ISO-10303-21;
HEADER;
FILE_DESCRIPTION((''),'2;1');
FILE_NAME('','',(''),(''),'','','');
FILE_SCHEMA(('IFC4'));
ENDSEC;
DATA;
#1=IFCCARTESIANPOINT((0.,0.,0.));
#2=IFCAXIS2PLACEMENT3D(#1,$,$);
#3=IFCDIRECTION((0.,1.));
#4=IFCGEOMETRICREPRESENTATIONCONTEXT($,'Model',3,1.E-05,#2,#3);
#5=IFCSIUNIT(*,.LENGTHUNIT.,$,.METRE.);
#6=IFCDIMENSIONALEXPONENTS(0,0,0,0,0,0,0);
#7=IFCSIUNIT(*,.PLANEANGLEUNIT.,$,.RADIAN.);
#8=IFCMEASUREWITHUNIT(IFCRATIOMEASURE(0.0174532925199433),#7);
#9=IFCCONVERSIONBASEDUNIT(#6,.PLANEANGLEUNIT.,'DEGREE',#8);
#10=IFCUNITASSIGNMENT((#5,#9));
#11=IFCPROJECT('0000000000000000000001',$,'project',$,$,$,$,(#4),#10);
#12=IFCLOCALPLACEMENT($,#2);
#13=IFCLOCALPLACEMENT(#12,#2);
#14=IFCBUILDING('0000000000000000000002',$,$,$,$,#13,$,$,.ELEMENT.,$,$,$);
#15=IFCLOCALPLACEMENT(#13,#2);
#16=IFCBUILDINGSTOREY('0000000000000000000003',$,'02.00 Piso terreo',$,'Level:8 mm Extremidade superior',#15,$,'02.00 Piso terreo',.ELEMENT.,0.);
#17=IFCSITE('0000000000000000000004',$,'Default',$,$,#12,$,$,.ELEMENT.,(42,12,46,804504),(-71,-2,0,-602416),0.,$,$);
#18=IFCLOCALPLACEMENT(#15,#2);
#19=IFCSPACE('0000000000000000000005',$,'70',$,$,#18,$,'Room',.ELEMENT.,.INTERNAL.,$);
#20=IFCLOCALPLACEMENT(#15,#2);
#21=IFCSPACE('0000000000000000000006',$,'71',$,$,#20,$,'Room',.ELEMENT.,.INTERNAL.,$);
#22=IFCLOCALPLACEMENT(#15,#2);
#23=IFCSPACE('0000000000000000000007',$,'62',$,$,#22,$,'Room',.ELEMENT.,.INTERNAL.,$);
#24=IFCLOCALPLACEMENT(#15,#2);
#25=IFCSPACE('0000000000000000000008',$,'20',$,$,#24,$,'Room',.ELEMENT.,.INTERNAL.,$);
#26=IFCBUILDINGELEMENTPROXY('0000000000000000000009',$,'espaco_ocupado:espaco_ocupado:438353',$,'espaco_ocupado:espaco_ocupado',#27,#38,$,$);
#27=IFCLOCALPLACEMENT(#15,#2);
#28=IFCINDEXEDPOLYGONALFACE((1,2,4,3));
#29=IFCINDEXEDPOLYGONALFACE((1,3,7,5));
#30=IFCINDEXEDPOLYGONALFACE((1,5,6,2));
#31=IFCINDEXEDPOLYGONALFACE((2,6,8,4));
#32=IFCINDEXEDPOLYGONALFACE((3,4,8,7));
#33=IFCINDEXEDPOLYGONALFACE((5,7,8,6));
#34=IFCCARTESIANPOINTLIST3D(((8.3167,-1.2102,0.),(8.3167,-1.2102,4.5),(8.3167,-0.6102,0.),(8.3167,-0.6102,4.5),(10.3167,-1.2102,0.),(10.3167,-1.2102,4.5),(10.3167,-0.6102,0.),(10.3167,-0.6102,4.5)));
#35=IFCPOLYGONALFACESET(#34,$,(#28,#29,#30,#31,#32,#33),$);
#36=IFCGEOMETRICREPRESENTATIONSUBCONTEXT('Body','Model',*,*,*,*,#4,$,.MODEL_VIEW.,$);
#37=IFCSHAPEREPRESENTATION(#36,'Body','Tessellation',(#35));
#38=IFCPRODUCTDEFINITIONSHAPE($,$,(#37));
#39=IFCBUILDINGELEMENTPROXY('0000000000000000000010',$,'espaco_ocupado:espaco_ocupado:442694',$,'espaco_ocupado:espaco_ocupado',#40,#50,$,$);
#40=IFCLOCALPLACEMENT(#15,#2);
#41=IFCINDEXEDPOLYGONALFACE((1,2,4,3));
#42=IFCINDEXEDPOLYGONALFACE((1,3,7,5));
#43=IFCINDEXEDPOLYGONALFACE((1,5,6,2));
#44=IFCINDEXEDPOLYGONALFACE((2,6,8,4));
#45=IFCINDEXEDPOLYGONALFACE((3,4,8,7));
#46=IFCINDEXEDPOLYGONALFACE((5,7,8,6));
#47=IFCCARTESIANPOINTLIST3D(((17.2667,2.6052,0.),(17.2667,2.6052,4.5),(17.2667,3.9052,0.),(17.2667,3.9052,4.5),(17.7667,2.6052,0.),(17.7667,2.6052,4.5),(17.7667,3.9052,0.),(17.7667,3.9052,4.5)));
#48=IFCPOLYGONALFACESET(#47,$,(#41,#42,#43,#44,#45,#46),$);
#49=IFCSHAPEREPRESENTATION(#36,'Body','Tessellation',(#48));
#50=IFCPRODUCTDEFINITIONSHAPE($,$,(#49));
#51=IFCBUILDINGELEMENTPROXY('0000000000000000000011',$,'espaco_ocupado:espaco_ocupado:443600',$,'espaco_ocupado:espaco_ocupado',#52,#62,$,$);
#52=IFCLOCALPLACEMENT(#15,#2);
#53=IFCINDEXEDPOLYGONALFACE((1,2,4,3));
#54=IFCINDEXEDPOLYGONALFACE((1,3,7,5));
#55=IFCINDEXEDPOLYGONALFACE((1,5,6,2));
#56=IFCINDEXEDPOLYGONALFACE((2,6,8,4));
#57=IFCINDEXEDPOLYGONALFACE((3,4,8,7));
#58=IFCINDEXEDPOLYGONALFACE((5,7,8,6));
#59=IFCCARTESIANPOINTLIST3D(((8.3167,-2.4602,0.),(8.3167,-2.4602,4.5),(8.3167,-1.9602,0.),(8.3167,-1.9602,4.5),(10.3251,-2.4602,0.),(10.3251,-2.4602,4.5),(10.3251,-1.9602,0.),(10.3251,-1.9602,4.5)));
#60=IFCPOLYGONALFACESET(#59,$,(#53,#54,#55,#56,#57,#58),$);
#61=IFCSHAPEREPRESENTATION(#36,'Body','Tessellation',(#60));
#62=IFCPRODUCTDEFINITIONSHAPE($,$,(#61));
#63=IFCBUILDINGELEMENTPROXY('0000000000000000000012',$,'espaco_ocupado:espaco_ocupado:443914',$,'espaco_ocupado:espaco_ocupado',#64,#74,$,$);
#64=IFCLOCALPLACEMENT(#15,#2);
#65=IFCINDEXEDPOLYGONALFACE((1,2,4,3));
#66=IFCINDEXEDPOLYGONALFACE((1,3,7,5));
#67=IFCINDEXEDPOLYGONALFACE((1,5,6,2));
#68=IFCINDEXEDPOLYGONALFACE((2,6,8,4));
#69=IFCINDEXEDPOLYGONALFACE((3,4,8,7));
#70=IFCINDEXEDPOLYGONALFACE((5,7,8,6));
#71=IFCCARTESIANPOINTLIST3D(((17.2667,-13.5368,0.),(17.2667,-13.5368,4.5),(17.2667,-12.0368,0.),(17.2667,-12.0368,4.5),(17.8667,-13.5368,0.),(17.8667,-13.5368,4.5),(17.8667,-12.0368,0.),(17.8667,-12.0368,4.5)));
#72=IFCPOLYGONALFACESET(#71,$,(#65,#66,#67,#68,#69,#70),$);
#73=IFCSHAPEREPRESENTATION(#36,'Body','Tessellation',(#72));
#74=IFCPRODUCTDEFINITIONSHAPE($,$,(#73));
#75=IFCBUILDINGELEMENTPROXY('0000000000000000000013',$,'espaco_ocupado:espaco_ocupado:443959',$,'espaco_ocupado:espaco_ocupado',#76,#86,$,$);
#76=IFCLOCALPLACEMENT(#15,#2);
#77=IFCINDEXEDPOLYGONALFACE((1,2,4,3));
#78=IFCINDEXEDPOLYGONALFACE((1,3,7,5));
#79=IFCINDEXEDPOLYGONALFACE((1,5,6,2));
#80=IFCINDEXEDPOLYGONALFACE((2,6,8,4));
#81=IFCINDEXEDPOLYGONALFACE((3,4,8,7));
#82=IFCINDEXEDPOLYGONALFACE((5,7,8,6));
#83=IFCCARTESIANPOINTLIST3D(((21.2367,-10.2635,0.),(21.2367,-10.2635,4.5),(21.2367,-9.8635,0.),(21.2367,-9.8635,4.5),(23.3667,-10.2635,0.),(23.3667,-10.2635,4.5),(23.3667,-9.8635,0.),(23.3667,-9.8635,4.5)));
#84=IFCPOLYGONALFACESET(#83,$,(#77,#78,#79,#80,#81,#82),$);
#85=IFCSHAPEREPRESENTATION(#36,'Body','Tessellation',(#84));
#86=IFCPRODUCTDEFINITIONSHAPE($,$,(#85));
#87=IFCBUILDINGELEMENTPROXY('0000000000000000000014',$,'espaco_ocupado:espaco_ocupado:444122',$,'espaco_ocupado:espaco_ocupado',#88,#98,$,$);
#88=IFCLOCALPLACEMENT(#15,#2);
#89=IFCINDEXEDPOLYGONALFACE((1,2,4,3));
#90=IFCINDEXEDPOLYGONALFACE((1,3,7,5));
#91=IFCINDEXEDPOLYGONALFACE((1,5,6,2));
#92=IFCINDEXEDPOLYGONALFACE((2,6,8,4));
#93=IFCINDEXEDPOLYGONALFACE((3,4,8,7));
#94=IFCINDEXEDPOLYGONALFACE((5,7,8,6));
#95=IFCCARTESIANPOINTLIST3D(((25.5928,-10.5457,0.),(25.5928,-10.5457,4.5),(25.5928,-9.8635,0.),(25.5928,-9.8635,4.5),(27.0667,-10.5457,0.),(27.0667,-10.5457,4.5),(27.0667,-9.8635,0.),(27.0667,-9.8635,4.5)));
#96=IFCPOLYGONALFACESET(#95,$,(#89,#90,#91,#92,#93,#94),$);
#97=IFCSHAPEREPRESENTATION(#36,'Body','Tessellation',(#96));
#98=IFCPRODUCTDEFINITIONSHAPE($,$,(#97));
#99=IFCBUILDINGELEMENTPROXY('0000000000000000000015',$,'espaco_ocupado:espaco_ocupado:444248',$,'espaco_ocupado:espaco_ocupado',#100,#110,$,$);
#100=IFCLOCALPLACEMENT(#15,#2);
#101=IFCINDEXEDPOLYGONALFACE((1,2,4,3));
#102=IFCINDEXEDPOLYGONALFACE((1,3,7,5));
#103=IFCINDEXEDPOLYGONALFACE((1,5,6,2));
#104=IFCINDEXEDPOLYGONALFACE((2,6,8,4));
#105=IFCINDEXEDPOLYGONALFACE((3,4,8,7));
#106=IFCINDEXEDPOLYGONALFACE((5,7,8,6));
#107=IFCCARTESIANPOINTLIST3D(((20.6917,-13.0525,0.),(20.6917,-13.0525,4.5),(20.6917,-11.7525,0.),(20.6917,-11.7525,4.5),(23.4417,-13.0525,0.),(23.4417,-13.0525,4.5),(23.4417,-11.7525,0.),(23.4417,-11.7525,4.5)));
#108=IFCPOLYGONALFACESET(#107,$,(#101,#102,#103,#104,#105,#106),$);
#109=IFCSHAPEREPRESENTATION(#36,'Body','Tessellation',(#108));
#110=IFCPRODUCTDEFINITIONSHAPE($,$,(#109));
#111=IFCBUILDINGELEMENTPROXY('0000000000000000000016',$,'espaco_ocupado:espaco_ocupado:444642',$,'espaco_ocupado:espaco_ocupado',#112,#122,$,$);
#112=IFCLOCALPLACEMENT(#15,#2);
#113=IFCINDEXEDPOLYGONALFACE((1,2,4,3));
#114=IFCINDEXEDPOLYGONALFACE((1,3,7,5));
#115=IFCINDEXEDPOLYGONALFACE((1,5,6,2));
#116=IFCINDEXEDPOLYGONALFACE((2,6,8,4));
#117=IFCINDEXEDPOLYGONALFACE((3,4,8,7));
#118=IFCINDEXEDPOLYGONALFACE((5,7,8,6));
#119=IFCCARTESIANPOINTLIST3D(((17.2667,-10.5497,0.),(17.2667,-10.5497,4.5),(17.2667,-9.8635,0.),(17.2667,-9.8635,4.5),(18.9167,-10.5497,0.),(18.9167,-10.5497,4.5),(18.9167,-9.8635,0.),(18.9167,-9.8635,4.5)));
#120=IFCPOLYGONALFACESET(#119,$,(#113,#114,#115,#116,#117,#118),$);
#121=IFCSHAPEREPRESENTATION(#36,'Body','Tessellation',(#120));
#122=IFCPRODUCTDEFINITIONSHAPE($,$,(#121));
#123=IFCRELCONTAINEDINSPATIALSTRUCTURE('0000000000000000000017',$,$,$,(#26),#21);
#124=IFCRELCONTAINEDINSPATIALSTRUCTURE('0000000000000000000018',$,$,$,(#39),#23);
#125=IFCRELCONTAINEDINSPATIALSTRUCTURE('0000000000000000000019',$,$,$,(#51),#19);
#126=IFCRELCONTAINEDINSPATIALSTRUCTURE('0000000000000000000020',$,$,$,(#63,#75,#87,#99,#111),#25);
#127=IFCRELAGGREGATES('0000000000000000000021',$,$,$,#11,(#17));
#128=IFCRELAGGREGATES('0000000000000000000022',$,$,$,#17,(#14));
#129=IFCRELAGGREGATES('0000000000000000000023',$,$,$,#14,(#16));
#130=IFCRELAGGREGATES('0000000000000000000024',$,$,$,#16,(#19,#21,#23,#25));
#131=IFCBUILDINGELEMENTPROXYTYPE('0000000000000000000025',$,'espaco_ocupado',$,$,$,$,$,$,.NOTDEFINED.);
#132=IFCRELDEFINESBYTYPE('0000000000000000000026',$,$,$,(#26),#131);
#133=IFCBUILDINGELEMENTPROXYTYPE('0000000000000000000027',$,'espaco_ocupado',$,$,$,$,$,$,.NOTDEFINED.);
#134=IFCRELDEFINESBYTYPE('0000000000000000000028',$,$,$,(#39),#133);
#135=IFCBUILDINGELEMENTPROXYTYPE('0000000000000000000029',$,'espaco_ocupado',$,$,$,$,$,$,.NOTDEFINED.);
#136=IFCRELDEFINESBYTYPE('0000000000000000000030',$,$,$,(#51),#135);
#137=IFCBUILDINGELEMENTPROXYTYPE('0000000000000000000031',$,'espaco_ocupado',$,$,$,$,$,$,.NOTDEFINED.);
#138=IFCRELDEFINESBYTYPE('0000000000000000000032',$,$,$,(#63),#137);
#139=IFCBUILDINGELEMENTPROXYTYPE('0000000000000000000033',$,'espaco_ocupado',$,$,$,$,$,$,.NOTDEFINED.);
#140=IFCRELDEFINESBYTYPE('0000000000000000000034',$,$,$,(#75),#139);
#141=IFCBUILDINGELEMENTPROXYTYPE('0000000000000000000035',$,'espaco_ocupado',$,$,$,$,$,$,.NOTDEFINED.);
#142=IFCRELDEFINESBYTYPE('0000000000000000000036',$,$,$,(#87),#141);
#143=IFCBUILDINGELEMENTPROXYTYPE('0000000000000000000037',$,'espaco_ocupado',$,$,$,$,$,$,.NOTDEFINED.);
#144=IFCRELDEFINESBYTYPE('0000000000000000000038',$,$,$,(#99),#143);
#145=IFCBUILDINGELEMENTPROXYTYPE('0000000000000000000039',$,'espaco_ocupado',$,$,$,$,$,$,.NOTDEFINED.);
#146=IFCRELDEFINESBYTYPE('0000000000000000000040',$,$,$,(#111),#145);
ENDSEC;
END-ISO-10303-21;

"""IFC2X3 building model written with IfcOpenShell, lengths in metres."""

from ifc_helpers import new_model, entity, si_unit, converted_unit, direction, frame, origin, origin_2d_with_axis, place, context, subcontext, project, spatial, rectangle, extrude, source, transform, mapped, type_object, type_shapes, element, save


model = new_model("IFC2X3")

# Units and contexts
model_context = context("Model", 3, precision=1e-05, world=origin(), true_north=direction((0.0, 1.0)))
body_context = subcontext(model_context, "Body", "Model", "MODEL_VIEW")
ifc_project = project(units=[si_unit("LENGTHUNIT", "METRE"), converted_unit("PLANEANGLEUNIT", "DEGREE", entity("IfcRatioMeasure", 0.0174532925199433), si_unit("PLANEANGLEUNIT", "RADIAN"), dimensions=[0, 0, 0, 0, 0, 0, 0])], contexts=[model_context])

# Site, building, storey
site_placement = place(None, origin())
site = spatial("IfcSite", under=ifc_project, at=site_placement, Name="Default", CompositionType="ELEMENT", RefLatitude=(42, 12, 46, 804504), RefLongitude=(-71, -2, 0, -602416), RefElevation=0.0)
building_placement = place(site_placement, origin())
building = spatial("IfcBuilding", under=site, at=building_placement, CompositionType="ELEMENT")
storey_placement = place(building_placement, origin())
storey = spatial("IfcBuildingStorey", under=building, at=storey_placement, Name="02.00 Piso terreo", ObjectType="Level:8 mm Extremidade superior", LongName="02.00 Piso terreo", CompositionType="ELEMENT", Elevation=0.0)

# Shared definitions
space_1_placement = place(storey_placement, origin())
space_1 = spatial("IfcSpace", under=storey, at=space_1_placement, Name="70", LongName="Room", CompositionType="ELEMENT", InteriorOrExteriorSpace="INTERNAL")

# Shared definitions
space_2_placement = place(storey_placement, origin())
space_2 = spatial("IfcSpace", under=storey, at=space_2_placement, Name="71", LongName="Room", CompositionType="ELEMENT", InteriorOrExteriorSpace="INTERNAL")

# Building element proxy
building_element_proxy_type_1 = type_object("IfcBuildingElementProxyType", Name="espaco_ocupado", PredefinedType="NOTDEFINED")
shared_shape_1 = source(origin(), body_context, "Body", "SweptSolid", [
    extrude(rectangle(XDim=2.0, YDim=0.6, at=origin_2d_with_axis()), frame((0.0, 0.0, 0.0), z_axis=(0.0, 0.0, 1.0), x_axis=(-1.0, 0.0, 0.0)), (0.0, 0.0, 1.0), 4.5),
])
type_shapes(building_element_proxy_type_1, [shared_shape_1])
proxy_1_placement = place(space_2_placement, frame((9.3167, -0.9102, 0.0)))
element("IfcBuildingElementProxy", 1, at=proxy_1_placement, inside=space_2, type_object=building_element_proxy_type_1, Name="espaco_ocupado:espaco_ocupado:438353", ObjectType="espaco_ocupado:espaco_ocupado", context=body_context, shape_type="MappedRepresentation", body=[
    mapped(shared_shape_1, transform((0.0, 0.0, 0.0), scale=1.0)),
])

# Shared definitions
space_3_placement = place(storey_placement, origin())
space_3 = spatial("IfcSpace", under=storey, at=space_3_placement, Name="62", LongName="Room", CompositionType="ELEMENT", InteriorOrExteriorSpace="INTERNAL")

# Building element proxies
building_element_proxy_type_2 = type_object("IfcBuildingElementProxyType", Name="espaco_ocupado", PredefinedType="NOTDEFINED")
shared_shape_2 = source(origin(), body_context, "Body", "SweptSolid", [
    extrude(rectangle(XDim=0.5, YDim=1.3, at=origin_2d_with_axis()), frame((0.0, 0.0, 0.0), z_axis=(0.0, 0.0, 1.0), x_axis=(-1.0, 0.0, 0.0)), (0.0, 0.0, 1.0), 4.5),
])
type_shapes(building_element_proxy_type_2, [shared_shape_2])
proxy_2_placement = place(space_3_placement, frame((17.5167, 3.2552, 0.0)))
element("IfcBuildingElementProxy", 2, at=proxy_2_placement, inside=space_3, type_object=building_element_proxy_type_2, Name="espaco_ocupado:espaco_ocupado:442694", ObjectType="espaco_ocupado:espaco_ocupado", context=body_context, shape_type="MappedRepresentation", body=[
    mapped(shared_shape_2, transform((0.0, 0.0, 0.0), scale=1.0)),
])
building_element_proxy_type_3 = type_object("IfcBuildingElementProxyType", Name="espaco_ocupado", PredefinedType="NOTDEFINED")
shared_shape_3 = source(origin(), body_context, "Body", "SweptSolid", [
    extrude(rectangle(XDim=0.5, YDim=2.0084, at=origin_2d_with_axis()), frame((0.0, 0.0, 0.0), z_axis=(0.0, 0.0, 1.0), x_axis=(-1.0, 0.0, 0.0)), (0.0, 0.0, 1.0), 4.5),
])
type_shapes(building_element_proxy_type_3, [shared_shape_3])
proxy_3_placement = place(space_1_placement, frame((9.3209, -2.2102, 0.0), z_axis=(0.0, 0.0, 1.0), x_axis=(0.0, -1.0, 0.0)))
element("IfcBuildingElementProxy", 3, at=proxy_3_placement, inside=space_1, type_object=building_element_proxy_type_3, Name="espaco_ocupado:espaco_ocupado:443600", ObjectType="espaco_ocupado:espaco_ocupado", context=body_context, shape_type="MappedRepresentation", body=[
    mapped(shared_shape_3, transform((0.0, 0.0, 0.0), scale=1.0)),
])

# Shared definitions
space_4_placement = place(storey_placement, origin())
space_4 = spatial("IfcSpace", under=storey, at=space_4_placement, Name="20", LongName="Room", CompositionType="ELEMENT", InteriorOrExteriorSpace="INTERNAL")

# Building element proxies
building_element_proxy_type_4 = type_object("IfcBuildingElementProxyType", Name="espaco_ocupado", PredefinedType="NOTDEFINED")
shared_shape_4 = source(origin(), body_context, "Body", "SweptSolid", [
    extrude(rectangle(XDim=0.6, YDim=1.5, at=origin_2d_with_axis()), frame((0.0, 0.0, 0.0), z_axis=(0.0, 0.0, 1.0), x_axis=(-1.0, 0.0, 0.0)), (0.0, 0.0, 1.0), 4.5),
])
type_shapes(building_element_proxy_type_4, [shared_shape_4])
proxy_4_placement = place(space_4_placement, frame((17.5667, -12.7868, 0.0)))
element("IfcBuildingElementProxy", 4, at=proxy_4_placement, inside=space_4, type_object=building_element_proxy_type_4, Name="espaco_ocupado:espaco_ocupado:443914", ObjectType="espaco_ocupado:espaco_ocupado", context=body_context, shape_type="MappedRepresentation", body=[
    mapped(shared_shape_4, transform((0.0, 0.0, 0.0), scale=1.0)),
])
building_element_proxy_type_5 = type_object("IfcBuildingElementProxyType", Name="espaco_ocupado", PredefinedType="NOTDEFINED")
shared_shape_5 = source(origin(), body_context, "Body", "SweptSolid", [
    extrude(rectangle(XDim=2.13, YDim=0.4, at=origin_2d_with_axis()), frame((0.0, 0.0, 0.0), z_axis=(0.0, 0.0, 1.0), x_axis=(-1.0, 0.0, 0.0)), (0.0, 0.0, 1.0), 4.5),
])
type_shapes(building_element_proxy_type_5, [shared_shape_5])
proxy_5_placement = place(space_4_placement, frame((22.3017, -10.0635, 0.0)))
element("IfcBuildingElementProxy", 5, at=proxy_5_placement, inside=space_4, type_object=building_element_proxy_type_5, Name="espaco_ocupado:espaco_ocupado:443959", ObjectType="espaco_ocupado:espaco_ocupado", context=body_context, shape_type="MappedRepresentation", body=[
    mapped(shared_shape_5, transform((0.0, 0.0, 0.0), scale=1.0)),
])
building_element_proxy_type_6 = type_object("IfcBuildingElementProxyType", Name="espaco_ocupado", PredefinedType="NOTDEFINED")
shared_shape_6 = source(origin(), body_context, "Body", "SweptSolid", [
    extrude(rectangle(XDim=1.4739, YDim=0.6822, at=origin_2d_with_axis()), frame((0.0, 0.0, 0.0), z_axis=(0.0, 0.0, 1.0), x_axis=(-1.0, 0.0, 0.0)), (0.0, 0.0, 1.0), 4.5),
])
type_shapes(building_element_proxy_type_6, [shared_shape_6])
proxy_6_placement = place(space_4_placement, frame((26.3297, -10.2046, 0.0)))
element("IfcBuildingElementProxy", 6, at=proxy_6_placement, inside=space_4, type_object=building_element_proxy_type_6, Name="espaco_ocupado:espaco_ocupado:444122", ObjectType="espaco_ocupado:espaco_ocupado", context=body_context, shape_type="MappedRepresentation", body=[
    mapped(shared_shape_6, transform((0.0, 0.0, 0.0), scale=1.0)),
])
building_element_proxy_type_7 = type_object("IfcBuildingElementProxyType", Name="espaco_ocupado", PredefinedType="NOTDEFINED")
shared_shape_7 = source(origin(), body_context, "Body", "SweptSolid", [
    extrude(rectangle(XDim=2.75, YDim=1.3, at=origin_2d_with_axis()), frame((0.0, 0.0, 0.0), z_axis=(0.0, 0.0, 1.0), x_axis=(-1.0, 0.0, 0.0)), (0.0, 0.0, 1.0), 4.5),
])
type_shapes(building_element_proxy_type_7, [shared_shape_7])
proxy_7_placement = place(space_4_placement, frame((22.0667, -12.4025, 0.0)))
element("IfcBuildingElementProxy", 7, at=proxy_7_placement, inside=space_4, type_object=building_element_proxy_type_7, Name="espaco_ocupado:espaco_ocupado:444248", ObjectType="espaco_ocupado:espaco_ocupado", context=body_context, shape_type="MappedRepresentation", body=[
    mapped(shared_shape_7, transform((0.0, 0.0, 0.0), scale=1.0)),
])
building_element_proxy_type_8 = type_object("IfcBuildingElementProxyType", Name="espaco_ocupado", PredefinedType="NOTDEFINED")
shared_shape_8 = source(origin(), body_context, "Body", "SweptSolid", [
    extrude(rectangle(XDim=1.65, YDim=0.6862, at=origin_2d_with_axis()), frame((0.0, 0.0, 0.0), z_axis=(0.0, 0.0, 1.0), x_axis=(-1.0, 0.0, 0.0)), (0.0, 0.0, 1.0), 4.5),
])
type_shapes(building_element_proxy_type_8, [shared_shape_8])
proxy_8_placement = place(space_4_placement, frame((18.0917, -10.2066, 0.0)))
element("IfcBuildingElementProxy", 8, at=proxy_8_placement, inside=space_4, type_object=building_element_proxy_type_8, Name="espaco_ocupado:espaco_ocupado:444642", ObjectType="espaco_ocupado:espaco_ocupado", context=body_context, shape_type="MappedRepresentation", body=[
    mapped(shared_shape_8, transform((0.0, 0.0, 0.0), scale=1.0)),
])

save(model, "model.ifc")
